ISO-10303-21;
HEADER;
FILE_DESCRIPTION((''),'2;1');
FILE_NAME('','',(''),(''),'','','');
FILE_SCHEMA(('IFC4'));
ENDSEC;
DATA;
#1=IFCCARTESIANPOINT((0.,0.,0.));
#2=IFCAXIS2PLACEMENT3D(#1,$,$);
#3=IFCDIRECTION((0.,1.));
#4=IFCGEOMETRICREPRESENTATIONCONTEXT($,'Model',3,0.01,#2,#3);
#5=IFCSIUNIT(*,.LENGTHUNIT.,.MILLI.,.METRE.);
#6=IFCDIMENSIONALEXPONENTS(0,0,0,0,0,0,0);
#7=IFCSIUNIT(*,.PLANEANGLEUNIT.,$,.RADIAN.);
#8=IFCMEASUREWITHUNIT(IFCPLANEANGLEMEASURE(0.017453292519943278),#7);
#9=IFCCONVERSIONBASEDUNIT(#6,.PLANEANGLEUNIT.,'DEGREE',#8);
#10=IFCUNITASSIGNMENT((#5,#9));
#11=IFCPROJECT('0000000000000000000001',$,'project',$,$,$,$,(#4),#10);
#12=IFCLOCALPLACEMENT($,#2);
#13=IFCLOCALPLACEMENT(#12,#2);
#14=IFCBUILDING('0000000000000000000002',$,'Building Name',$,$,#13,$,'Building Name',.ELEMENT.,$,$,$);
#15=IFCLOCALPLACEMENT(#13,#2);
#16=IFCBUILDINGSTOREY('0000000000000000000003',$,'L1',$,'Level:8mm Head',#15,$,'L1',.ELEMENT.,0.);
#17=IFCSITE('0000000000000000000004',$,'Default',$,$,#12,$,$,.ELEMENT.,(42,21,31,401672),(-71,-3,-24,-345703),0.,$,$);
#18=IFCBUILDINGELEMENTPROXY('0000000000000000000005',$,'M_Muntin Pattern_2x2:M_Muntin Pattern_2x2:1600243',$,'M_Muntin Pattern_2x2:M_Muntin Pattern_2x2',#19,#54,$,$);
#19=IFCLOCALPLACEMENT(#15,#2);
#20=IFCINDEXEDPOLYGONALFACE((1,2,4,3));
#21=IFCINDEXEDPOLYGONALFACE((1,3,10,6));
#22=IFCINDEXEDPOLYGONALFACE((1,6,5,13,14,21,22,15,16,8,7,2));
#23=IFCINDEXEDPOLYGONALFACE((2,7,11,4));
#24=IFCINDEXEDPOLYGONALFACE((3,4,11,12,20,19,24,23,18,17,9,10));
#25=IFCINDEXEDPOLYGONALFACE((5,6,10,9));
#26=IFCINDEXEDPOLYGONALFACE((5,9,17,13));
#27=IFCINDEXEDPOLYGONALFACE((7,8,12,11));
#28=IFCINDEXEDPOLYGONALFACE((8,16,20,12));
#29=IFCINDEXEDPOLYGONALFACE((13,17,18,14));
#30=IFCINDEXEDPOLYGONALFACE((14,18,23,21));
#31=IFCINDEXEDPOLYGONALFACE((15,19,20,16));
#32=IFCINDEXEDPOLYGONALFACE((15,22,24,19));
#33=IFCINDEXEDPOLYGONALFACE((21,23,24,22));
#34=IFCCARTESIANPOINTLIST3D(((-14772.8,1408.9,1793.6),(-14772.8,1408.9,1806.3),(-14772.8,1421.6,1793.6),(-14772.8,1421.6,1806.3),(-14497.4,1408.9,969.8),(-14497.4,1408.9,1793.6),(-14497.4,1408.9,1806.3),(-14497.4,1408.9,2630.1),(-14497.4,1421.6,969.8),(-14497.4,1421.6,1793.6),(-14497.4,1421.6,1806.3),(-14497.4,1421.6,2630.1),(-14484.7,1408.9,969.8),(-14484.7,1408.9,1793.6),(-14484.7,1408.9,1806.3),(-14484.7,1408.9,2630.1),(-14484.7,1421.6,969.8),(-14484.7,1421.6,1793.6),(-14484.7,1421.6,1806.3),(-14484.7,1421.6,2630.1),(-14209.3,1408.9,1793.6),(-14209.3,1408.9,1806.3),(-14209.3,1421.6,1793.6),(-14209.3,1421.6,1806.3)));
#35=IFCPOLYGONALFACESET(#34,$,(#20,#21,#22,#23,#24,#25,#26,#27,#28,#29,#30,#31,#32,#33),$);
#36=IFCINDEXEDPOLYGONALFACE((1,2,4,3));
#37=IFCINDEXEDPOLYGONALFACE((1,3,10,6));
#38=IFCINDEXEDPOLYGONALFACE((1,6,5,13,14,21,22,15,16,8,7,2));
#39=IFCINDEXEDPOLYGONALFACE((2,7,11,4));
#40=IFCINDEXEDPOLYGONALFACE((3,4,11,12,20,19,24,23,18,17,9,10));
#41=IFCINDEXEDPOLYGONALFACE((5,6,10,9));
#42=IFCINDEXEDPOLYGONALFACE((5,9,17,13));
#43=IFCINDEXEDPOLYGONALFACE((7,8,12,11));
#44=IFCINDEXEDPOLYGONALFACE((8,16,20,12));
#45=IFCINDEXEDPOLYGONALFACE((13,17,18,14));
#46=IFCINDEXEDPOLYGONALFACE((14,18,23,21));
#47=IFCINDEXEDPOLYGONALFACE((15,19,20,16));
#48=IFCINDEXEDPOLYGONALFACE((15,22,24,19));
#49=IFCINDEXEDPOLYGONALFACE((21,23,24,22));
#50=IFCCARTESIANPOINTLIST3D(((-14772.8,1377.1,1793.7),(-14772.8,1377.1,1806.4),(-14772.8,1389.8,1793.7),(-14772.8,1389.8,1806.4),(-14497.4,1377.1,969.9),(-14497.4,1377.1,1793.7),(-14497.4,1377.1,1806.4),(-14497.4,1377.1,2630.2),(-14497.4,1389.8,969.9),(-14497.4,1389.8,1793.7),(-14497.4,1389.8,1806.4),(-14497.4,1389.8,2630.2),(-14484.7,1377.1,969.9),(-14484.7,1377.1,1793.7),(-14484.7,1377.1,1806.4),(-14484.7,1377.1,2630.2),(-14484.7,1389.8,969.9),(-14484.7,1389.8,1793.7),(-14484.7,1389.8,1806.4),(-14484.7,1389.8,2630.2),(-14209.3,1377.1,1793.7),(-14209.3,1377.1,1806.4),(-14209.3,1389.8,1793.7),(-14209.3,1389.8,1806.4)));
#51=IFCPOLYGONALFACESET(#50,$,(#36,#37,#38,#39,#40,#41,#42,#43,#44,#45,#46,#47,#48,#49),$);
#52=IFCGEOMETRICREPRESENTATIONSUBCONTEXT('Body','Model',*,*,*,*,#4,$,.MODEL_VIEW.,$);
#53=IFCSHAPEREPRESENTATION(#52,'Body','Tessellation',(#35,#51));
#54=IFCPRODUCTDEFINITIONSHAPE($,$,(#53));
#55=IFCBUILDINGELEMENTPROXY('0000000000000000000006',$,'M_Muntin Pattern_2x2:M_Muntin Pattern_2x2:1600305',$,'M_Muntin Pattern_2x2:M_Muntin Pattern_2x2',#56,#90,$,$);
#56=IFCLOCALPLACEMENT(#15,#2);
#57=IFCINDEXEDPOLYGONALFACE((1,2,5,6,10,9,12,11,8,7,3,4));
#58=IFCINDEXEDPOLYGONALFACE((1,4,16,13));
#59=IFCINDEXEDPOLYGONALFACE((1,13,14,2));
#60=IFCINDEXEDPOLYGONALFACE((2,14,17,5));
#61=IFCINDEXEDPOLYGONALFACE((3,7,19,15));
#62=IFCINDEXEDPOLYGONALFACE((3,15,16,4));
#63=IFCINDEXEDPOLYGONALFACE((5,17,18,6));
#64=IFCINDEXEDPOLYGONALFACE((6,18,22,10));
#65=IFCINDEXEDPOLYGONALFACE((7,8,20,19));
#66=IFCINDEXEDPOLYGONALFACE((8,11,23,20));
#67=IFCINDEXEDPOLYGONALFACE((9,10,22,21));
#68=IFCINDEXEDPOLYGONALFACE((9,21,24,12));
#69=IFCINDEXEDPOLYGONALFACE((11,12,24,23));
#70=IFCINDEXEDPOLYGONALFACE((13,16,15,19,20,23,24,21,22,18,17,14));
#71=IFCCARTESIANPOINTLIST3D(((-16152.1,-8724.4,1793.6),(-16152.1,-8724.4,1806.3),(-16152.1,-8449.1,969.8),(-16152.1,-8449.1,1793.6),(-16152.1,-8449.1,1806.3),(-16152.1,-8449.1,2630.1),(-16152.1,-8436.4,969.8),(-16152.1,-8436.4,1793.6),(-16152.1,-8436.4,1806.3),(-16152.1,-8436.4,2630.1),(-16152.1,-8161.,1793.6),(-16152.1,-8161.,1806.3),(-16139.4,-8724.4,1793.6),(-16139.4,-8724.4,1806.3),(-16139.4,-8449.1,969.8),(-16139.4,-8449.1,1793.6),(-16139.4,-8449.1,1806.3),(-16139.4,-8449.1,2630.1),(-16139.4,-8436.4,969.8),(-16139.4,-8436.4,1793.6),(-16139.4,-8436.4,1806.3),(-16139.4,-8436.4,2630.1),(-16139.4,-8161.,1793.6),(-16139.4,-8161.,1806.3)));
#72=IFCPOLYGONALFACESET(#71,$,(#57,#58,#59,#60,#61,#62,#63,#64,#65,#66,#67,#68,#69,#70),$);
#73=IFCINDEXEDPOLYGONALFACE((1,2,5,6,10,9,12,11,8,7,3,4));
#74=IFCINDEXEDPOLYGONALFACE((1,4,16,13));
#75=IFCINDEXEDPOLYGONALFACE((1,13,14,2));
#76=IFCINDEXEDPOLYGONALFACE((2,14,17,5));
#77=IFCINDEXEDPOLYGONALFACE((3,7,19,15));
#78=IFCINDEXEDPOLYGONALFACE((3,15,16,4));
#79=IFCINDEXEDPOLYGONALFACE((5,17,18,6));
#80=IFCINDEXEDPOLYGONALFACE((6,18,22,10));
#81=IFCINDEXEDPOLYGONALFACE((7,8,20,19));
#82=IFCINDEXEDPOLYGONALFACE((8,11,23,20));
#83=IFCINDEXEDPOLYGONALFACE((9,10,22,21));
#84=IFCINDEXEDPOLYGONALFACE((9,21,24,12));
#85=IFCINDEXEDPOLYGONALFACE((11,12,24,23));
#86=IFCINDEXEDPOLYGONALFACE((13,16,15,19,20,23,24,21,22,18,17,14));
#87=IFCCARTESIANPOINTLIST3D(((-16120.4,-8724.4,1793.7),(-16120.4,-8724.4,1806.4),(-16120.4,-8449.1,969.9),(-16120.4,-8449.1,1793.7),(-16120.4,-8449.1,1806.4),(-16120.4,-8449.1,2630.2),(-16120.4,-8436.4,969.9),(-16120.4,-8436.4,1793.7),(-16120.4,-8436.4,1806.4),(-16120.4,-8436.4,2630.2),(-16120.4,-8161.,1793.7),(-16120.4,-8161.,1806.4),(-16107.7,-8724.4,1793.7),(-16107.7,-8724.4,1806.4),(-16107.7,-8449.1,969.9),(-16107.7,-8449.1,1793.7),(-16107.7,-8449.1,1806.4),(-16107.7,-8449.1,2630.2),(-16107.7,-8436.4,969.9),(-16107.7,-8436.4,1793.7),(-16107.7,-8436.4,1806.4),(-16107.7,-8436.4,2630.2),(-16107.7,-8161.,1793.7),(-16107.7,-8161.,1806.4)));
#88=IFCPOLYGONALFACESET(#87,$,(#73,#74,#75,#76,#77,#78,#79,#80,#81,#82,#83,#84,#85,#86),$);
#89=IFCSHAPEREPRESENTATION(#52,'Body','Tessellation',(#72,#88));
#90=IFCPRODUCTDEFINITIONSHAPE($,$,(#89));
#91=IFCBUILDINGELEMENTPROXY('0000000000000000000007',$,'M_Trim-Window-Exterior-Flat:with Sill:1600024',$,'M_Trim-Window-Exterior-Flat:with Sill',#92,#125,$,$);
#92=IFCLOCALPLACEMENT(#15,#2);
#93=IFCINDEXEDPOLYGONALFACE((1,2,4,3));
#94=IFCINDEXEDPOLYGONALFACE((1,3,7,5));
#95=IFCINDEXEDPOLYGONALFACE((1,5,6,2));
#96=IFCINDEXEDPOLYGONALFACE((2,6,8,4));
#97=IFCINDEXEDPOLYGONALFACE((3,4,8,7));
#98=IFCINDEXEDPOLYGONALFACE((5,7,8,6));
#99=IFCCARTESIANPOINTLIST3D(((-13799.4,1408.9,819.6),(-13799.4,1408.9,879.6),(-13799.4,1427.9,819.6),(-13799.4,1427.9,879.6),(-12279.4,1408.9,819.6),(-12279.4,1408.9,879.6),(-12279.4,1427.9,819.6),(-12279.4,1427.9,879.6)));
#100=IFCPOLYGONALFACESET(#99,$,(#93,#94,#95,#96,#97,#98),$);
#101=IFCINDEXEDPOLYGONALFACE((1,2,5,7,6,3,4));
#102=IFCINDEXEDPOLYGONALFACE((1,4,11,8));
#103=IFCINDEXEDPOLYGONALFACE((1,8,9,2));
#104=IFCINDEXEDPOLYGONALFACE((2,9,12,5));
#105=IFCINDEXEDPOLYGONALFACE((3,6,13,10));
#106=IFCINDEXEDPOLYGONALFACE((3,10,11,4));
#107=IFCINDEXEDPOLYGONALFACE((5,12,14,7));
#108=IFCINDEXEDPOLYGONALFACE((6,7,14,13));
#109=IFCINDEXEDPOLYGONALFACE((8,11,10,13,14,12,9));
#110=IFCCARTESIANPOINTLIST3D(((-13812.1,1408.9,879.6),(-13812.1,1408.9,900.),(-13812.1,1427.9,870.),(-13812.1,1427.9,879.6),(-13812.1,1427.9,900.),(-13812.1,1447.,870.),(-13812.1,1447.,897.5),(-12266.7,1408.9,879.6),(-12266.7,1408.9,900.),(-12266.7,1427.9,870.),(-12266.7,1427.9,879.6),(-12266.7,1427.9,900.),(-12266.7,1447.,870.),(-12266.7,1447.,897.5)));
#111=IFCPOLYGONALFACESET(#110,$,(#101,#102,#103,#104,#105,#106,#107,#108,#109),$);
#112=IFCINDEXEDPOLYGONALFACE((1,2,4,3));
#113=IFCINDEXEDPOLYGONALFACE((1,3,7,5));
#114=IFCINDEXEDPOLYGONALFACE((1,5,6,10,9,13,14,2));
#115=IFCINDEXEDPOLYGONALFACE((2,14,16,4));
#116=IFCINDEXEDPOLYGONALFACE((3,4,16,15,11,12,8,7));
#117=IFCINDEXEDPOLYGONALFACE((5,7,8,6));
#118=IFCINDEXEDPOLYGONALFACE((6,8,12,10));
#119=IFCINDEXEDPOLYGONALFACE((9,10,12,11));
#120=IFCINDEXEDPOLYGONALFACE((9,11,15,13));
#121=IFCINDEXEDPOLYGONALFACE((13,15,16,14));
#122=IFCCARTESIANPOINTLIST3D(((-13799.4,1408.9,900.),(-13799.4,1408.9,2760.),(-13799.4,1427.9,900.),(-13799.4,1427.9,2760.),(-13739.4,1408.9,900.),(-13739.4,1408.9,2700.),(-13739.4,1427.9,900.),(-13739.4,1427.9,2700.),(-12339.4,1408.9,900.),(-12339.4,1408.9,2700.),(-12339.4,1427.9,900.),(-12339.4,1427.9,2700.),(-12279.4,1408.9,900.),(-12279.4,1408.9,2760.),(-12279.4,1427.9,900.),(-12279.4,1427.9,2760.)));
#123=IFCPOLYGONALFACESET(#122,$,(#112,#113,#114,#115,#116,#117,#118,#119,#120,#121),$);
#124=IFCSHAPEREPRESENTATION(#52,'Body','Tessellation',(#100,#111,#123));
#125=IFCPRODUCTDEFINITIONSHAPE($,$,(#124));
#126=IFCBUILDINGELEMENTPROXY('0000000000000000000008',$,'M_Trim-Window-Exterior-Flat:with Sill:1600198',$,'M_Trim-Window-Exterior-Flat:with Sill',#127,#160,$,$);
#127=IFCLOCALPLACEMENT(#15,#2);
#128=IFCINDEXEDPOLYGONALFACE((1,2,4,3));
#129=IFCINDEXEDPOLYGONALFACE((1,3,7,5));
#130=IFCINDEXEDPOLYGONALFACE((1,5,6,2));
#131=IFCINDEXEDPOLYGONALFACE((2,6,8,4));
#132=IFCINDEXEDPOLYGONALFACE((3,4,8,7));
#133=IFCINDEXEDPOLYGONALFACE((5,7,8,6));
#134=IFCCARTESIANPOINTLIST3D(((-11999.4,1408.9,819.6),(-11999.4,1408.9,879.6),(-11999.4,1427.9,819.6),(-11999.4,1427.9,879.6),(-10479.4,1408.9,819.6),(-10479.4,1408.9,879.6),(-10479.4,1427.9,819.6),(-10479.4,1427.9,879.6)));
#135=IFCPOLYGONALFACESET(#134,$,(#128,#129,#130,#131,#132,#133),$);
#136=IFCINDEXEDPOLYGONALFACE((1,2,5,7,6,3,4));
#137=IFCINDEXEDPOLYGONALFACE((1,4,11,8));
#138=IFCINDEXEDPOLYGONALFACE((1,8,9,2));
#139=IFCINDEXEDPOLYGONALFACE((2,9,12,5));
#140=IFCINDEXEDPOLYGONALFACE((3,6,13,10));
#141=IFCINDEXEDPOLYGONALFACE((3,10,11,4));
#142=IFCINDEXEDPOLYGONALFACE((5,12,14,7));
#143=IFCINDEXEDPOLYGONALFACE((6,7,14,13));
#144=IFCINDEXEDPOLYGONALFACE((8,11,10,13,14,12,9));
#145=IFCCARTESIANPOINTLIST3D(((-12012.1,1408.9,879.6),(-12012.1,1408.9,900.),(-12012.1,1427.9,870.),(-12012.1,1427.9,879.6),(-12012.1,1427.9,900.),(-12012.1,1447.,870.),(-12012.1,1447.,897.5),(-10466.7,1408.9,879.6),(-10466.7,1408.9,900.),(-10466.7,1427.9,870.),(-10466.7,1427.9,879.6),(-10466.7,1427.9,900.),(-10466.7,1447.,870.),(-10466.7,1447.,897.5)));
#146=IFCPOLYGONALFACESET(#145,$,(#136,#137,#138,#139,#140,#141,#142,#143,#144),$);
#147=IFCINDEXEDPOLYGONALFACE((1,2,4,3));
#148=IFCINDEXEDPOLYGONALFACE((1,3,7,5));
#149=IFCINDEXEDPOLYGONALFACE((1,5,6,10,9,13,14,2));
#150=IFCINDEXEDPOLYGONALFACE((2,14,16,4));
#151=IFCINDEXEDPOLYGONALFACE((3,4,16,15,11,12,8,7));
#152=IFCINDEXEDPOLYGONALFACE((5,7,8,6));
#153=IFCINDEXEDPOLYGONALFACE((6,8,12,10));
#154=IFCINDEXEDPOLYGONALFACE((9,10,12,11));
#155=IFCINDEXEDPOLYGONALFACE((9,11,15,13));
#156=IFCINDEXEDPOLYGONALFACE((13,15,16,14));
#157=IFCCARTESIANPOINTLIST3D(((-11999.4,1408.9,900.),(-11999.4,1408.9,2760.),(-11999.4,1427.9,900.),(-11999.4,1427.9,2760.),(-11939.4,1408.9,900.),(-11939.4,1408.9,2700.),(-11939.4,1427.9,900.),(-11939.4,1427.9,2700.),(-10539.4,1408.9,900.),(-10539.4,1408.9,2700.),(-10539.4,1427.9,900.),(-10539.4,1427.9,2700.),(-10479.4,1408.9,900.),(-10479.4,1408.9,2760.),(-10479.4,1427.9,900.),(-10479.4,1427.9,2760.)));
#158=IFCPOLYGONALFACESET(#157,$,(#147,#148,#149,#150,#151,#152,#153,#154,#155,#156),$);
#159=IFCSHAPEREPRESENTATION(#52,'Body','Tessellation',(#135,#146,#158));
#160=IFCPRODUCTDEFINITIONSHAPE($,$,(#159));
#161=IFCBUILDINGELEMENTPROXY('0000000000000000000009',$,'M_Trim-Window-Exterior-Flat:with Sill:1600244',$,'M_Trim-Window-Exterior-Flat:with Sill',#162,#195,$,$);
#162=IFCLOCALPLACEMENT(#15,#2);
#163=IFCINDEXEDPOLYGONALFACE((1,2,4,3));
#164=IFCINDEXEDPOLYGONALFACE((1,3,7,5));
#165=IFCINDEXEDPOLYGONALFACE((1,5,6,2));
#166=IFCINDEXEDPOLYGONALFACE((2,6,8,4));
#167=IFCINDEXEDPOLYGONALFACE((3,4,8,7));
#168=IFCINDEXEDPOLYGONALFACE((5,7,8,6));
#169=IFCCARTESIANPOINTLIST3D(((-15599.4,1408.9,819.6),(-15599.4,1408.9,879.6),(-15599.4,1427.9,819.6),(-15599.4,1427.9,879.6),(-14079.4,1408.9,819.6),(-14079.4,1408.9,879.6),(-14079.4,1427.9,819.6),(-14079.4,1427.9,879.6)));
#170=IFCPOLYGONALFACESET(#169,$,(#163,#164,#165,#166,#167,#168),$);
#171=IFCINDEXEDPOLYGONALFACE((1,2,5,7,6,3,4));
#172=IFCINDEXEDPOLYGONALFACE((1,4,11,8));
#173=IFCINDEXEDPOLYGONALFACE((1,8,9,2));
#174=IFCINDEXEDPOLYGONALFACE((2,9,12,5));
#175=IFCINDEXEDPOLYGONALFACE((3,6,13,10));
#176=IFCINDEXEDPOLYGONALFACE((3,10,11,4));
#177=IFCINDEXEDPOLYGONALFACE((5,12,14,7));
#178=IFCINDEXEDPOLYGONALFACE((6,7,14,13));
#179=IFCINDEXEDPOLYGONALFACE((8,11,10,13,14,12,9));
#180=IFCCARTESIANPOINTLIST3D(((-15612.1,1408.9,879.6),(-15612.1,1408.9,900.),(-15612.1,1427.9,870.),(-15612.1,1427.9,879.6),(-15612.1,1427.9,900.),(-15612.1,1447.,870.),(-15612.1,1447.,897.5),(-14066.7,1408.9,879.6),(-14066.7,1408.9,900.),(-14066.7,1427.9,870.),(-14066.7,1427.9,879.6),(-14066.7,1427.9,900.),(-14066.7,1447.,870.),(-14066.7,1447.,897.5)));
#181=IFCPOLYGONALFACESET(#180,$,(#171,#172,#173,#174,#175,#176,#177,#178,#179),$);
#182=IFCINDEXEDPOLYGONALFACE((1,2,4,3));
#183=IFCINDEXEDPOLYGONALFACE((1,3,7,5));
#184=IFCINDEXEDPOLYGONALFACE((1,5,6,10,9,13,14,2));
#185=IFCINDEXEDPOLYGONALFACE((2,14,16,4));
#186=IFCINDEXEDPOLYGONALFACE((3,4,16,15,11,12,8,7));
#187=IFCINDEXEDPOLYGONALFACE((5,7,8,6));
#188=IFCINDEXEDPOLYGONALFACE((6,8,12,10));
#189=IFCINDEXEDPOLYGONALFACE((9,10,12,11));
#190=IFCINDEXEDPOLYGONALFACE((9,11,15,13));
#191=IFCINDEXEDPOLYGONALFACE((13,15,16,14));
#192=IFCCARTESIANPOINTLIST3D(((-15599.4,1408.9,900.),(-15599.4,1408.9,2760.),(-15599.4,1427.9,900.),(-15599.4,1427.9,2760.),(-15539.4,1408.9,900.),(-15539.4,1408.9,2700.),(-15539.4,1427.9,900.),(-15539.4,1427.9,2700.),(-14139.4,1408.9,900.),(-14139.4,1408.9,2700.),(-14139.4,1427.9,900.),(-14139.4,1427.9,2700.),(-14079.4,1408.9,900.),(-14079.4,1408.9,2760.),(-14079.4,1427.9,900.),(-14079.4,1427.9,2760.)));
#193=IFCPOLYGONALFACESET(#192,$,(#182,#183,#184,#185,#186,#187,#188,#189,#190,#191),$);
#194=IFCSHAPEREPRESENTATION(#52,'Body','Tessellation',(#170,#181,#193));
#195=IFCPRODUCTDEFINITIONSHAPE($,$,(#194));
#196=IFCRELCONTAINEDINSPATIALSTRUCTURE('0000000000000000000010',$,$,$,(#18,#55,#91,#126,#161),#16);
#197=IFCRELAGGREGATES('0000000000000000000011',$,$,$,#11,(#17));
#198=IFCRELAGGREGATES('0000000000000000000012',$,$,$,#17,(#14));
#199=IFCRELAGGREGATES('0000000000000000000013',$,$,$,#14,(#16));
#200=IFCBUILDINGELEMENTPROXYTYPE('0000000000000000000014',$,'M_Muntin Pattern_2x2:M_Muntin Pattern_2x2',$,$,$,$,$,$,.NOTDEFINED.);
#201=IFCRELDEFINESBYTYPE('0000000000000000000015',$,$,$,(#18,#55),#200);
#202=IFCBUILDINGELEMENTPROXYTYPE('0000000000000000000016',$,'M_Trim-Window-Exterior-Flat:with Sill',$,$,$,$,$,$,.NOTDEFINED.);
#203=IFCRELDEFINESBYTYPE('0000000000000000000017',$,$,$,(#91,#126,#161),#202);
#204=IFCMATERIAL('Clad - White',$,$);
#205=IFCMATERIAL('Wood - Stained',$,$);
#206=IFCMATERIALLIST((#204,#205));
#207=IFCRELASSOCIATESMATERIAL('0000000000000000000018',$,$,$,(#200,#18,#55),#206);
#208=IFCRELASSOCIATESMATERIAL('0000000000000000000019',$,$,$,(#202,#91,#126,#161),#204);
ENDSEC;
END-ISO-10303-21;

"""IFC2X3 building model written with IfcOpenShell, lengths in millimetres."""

from ifc_helpers import new_model, entity, si_unit, converted_unit, direction, frame, frame_2d, origin, place, context, subcontext, project, spatial, polyline, rectangle, outline, extrude, source, transform, mapped, material, material_list, type_object, type_shapes, element, save


model = new_model("IFC2X3")

# Units and contexts
model_context = context("Model", 3, precision=0.01, world=origin(), true_north=direction((0.0, 1.0)))
body_context = subcontext(model_context, "Body", "Model", "MODEL_VIEW")
ifc_project = project(units=[si_unit("LENGTHUNIT", "METRE", prefix="MILLI"), converted_unit("PLANEANGLEUNIT", "DEGREE", entity("IfcPlaneAngleMeasure", 0.017453292519943278), si_unit("PLANEANGLEUNIT", "RADIAN"), dimensions=[0, 0, 0, 0, 0, 0, 0])], contexts=[model_context])

# Site, building, storey
site_placement = place(None, origin())
site = spatial("IfcSite", under=ifc_project, at=site_placement, Name="Default", CompositionType="ELEMENT", RefLatitude=(42, 21, 31, 401672), RefLongitude=(-71, -3, -24, -345703), RefElevation=0.0)
building_placement = place(site_placement, origin())
building = spatial("IfcBuilding", under=site, at=building_placement, Name="Building Name", LongName="Building Name", CompositionType="ELEMENT")
storey_placement = place(building_placement, origin())
storey = spatial("IfcBuildingStorey", under=building, at=storey_placement, Name="L1", ObjectType="Level:8mm Head", LongName="L1", CompositionType="ELEMENT", Elevation=0.0)

# Building element proxies
ifc_material_1 = material(Name="Clad - White")
ifc_material_2 = material(Name="Wood - Stained")
ifc_material_list = material_list([ifc_material_1, ifc_material_2])
building_element_proxy_type_1 = type_object("IfcBuildingElementProxyType", Name="M_Muntin Pattern_2x2:M_Muntin Pattern_2x2", PredefinedType="NOTDEFINED", material=ifc_material_list)
shared_shape_1 = source(origin(), body_context, "Body", "SweptSolid", [
    extrude(outline(polyline([(6.4, -6.4), (830.1, -6.4), (830.1, 6.3), (6.4, 6.3), (6.4, 281.7), (-6.3, 281.7), (-6.3, 6.3), (-830.2, 6.3), (-830.2, -6.4), (-6.3, -6.4), (-6.3, -281.7), (6.4, -281.7), (6.4, -6.4)])), frame((0.0, -22.2, 830.1), z_axis=(0.0, 1.0, 0.0), x_axis=(0.0, 0.0, 1.0)), (0.0, 0.0, 1.0), 12.7),
    extrude(outline(polyline([(6.4, -6.4), (830.2, -6.4), (830.2, 6.3), (6.4, 6.3), (6.4, 281.7), (-6.3, 281.7), (-6.3, 6.3), (-830.2, 6.3), (-830.2, -6.4), (-6.3, -6.4), (-6.3, -281.7), (6.4, -281.7), (6.4, -6.4)])), frame((0.0, 9.5, 830.2), z_axis=(0.0, 1.0, 0.0), x_axis=(0.0, 0.0, 1.0)), (0.0, 0.0, 1.0), 12.7),
])
type_shapes(building_element_proxy_type_1, [shared_shape_1])
for number, where, z_axis, x_axis, name in (
    (1, (-14491.0, 1399.4, 969.9), (0.0, 0.0, 1.0), (-1.0, 0.0, 0.0), "M_Muntin Pattern_2x2:M_Muntin Pattern_2x2:1600243"),
    (2, (-16129.9, -8442.7, 969.9), (0.0, 0.0, 1.0), (0.0, -1.0, 0.0), "M_Muntin Pattern_2x2:M_Muntin Pattern_2x2:1600305"),
):
    element("IfcBuildingElementProxy", number, at=place(storey_placement, frame(where, z_axis=z_axis, x_axis=x_axis)), inside=storey, type_object=building_element_proxy_type_1, material=ifc_material_list, Name=name, ObjectType="M_Muntin Pattern_2x2:M_Muntin Pattern_2x2", context=body_context, shape_type="MappedRepresentation", body=[
        mapped(shared_shape_1, transform((0.0, 0.0, 0.0), scale=1.0)),
    ])
building_element_proxy_type_2 = type_object("IfcBuildingElementProxyType", Name="M_Trim-Window-Exterior-Flat:with Sill", PredefinedType="NOTDEFINED", material=ifc_material_1)
shared_shape_2 = source(origin(), body_context, "Body", "SweptSolid", [
    extrude(rectangle(XDim=1520.0, YDim=60.0, at=frame_2d((0.0, 0.0), x_axis=(1.0, 0.0))), frame((0.0, -1850.4, 0.0), z_axis=(0.0, 0.0, 1.0), x_axis=(-1.0, 0.0, 0.0)), (0.0, 0.0, 1.0), 19.0),
    extrude(outline(polyline([(-19.0, -15.2), (0.0, -15.2), (0.0, -5.7), (19.0, -5.7), (19.0, 14.8), (0.0, 14.8), (-19.0, 12.3), (-19.0, -15.2)])), frame((-772.7, -1814.8, 19.0), z_axis=(1.0, 0.0, 0.0), x_axis=(0.0, 0.0, -1.0)), (0.0, 0.0, 1.0), 1545.4),
    extrude(outline(polyline([(-945.0, -760.0), (915.0, -760.0), (915.0, -700.0), (-885.0, -700.0), (-885.0, 700.0), (915.0, 700.0), (915.0, 760.0), (-945.0, 760.0), (-945.0, -760.0)])), frame((0.0, -885.0, 0.0), z_axis=(0.0, 0.0, 1.0), x_axis=(0.0, -1.0, 0.0)), (0.0, 0.0, 1.0), 19.0),
])
type_shapes(building_element_proxy_type_2, [shared_shape_2])
for number, where, z_axis, x_axis, name in (
    (3, (-13039.4, 1408.9, 2700.0), (0.0, 1.0, 0.0), (-1.0, 0.0, 0.0), "M_Trim-Window-Exterior-Flat:with Sill:1600024"),
    (4, (-11239.4, 1408.9, 2700.0), (0.0, 1.0, 0.0), (-1.0, 0.0, 0.0), "M_Trim-Window-Exterior-Flat:with Sill:1600198"),
    (5, (-14839.4, 1408.9, 2700.0), (0.0, 1.0, 0.0), (-1.0, 0.0, 0.0), "M_Trim-Window-Exterior-Flat:with Sill:1600244"),
):
    element("IfcBuildingElementProxy", number, at=place(storey_placement, frame(where, z_axis=z_axis, x_axis=x_axis)), inside=storey, type_object=building_element_proxy_type_2, material=ifc_material_1, Name=name, ObjectType="M_Trim-Window-Exterior-Flat:with Sill", context=body_context, shape_type="MappedRepresentation", body=[
        mapped(shared_shape_2, transform((0.0, 0.0, 0.0), scale=1.0)),
    ])

save(model, "model.ifc")
